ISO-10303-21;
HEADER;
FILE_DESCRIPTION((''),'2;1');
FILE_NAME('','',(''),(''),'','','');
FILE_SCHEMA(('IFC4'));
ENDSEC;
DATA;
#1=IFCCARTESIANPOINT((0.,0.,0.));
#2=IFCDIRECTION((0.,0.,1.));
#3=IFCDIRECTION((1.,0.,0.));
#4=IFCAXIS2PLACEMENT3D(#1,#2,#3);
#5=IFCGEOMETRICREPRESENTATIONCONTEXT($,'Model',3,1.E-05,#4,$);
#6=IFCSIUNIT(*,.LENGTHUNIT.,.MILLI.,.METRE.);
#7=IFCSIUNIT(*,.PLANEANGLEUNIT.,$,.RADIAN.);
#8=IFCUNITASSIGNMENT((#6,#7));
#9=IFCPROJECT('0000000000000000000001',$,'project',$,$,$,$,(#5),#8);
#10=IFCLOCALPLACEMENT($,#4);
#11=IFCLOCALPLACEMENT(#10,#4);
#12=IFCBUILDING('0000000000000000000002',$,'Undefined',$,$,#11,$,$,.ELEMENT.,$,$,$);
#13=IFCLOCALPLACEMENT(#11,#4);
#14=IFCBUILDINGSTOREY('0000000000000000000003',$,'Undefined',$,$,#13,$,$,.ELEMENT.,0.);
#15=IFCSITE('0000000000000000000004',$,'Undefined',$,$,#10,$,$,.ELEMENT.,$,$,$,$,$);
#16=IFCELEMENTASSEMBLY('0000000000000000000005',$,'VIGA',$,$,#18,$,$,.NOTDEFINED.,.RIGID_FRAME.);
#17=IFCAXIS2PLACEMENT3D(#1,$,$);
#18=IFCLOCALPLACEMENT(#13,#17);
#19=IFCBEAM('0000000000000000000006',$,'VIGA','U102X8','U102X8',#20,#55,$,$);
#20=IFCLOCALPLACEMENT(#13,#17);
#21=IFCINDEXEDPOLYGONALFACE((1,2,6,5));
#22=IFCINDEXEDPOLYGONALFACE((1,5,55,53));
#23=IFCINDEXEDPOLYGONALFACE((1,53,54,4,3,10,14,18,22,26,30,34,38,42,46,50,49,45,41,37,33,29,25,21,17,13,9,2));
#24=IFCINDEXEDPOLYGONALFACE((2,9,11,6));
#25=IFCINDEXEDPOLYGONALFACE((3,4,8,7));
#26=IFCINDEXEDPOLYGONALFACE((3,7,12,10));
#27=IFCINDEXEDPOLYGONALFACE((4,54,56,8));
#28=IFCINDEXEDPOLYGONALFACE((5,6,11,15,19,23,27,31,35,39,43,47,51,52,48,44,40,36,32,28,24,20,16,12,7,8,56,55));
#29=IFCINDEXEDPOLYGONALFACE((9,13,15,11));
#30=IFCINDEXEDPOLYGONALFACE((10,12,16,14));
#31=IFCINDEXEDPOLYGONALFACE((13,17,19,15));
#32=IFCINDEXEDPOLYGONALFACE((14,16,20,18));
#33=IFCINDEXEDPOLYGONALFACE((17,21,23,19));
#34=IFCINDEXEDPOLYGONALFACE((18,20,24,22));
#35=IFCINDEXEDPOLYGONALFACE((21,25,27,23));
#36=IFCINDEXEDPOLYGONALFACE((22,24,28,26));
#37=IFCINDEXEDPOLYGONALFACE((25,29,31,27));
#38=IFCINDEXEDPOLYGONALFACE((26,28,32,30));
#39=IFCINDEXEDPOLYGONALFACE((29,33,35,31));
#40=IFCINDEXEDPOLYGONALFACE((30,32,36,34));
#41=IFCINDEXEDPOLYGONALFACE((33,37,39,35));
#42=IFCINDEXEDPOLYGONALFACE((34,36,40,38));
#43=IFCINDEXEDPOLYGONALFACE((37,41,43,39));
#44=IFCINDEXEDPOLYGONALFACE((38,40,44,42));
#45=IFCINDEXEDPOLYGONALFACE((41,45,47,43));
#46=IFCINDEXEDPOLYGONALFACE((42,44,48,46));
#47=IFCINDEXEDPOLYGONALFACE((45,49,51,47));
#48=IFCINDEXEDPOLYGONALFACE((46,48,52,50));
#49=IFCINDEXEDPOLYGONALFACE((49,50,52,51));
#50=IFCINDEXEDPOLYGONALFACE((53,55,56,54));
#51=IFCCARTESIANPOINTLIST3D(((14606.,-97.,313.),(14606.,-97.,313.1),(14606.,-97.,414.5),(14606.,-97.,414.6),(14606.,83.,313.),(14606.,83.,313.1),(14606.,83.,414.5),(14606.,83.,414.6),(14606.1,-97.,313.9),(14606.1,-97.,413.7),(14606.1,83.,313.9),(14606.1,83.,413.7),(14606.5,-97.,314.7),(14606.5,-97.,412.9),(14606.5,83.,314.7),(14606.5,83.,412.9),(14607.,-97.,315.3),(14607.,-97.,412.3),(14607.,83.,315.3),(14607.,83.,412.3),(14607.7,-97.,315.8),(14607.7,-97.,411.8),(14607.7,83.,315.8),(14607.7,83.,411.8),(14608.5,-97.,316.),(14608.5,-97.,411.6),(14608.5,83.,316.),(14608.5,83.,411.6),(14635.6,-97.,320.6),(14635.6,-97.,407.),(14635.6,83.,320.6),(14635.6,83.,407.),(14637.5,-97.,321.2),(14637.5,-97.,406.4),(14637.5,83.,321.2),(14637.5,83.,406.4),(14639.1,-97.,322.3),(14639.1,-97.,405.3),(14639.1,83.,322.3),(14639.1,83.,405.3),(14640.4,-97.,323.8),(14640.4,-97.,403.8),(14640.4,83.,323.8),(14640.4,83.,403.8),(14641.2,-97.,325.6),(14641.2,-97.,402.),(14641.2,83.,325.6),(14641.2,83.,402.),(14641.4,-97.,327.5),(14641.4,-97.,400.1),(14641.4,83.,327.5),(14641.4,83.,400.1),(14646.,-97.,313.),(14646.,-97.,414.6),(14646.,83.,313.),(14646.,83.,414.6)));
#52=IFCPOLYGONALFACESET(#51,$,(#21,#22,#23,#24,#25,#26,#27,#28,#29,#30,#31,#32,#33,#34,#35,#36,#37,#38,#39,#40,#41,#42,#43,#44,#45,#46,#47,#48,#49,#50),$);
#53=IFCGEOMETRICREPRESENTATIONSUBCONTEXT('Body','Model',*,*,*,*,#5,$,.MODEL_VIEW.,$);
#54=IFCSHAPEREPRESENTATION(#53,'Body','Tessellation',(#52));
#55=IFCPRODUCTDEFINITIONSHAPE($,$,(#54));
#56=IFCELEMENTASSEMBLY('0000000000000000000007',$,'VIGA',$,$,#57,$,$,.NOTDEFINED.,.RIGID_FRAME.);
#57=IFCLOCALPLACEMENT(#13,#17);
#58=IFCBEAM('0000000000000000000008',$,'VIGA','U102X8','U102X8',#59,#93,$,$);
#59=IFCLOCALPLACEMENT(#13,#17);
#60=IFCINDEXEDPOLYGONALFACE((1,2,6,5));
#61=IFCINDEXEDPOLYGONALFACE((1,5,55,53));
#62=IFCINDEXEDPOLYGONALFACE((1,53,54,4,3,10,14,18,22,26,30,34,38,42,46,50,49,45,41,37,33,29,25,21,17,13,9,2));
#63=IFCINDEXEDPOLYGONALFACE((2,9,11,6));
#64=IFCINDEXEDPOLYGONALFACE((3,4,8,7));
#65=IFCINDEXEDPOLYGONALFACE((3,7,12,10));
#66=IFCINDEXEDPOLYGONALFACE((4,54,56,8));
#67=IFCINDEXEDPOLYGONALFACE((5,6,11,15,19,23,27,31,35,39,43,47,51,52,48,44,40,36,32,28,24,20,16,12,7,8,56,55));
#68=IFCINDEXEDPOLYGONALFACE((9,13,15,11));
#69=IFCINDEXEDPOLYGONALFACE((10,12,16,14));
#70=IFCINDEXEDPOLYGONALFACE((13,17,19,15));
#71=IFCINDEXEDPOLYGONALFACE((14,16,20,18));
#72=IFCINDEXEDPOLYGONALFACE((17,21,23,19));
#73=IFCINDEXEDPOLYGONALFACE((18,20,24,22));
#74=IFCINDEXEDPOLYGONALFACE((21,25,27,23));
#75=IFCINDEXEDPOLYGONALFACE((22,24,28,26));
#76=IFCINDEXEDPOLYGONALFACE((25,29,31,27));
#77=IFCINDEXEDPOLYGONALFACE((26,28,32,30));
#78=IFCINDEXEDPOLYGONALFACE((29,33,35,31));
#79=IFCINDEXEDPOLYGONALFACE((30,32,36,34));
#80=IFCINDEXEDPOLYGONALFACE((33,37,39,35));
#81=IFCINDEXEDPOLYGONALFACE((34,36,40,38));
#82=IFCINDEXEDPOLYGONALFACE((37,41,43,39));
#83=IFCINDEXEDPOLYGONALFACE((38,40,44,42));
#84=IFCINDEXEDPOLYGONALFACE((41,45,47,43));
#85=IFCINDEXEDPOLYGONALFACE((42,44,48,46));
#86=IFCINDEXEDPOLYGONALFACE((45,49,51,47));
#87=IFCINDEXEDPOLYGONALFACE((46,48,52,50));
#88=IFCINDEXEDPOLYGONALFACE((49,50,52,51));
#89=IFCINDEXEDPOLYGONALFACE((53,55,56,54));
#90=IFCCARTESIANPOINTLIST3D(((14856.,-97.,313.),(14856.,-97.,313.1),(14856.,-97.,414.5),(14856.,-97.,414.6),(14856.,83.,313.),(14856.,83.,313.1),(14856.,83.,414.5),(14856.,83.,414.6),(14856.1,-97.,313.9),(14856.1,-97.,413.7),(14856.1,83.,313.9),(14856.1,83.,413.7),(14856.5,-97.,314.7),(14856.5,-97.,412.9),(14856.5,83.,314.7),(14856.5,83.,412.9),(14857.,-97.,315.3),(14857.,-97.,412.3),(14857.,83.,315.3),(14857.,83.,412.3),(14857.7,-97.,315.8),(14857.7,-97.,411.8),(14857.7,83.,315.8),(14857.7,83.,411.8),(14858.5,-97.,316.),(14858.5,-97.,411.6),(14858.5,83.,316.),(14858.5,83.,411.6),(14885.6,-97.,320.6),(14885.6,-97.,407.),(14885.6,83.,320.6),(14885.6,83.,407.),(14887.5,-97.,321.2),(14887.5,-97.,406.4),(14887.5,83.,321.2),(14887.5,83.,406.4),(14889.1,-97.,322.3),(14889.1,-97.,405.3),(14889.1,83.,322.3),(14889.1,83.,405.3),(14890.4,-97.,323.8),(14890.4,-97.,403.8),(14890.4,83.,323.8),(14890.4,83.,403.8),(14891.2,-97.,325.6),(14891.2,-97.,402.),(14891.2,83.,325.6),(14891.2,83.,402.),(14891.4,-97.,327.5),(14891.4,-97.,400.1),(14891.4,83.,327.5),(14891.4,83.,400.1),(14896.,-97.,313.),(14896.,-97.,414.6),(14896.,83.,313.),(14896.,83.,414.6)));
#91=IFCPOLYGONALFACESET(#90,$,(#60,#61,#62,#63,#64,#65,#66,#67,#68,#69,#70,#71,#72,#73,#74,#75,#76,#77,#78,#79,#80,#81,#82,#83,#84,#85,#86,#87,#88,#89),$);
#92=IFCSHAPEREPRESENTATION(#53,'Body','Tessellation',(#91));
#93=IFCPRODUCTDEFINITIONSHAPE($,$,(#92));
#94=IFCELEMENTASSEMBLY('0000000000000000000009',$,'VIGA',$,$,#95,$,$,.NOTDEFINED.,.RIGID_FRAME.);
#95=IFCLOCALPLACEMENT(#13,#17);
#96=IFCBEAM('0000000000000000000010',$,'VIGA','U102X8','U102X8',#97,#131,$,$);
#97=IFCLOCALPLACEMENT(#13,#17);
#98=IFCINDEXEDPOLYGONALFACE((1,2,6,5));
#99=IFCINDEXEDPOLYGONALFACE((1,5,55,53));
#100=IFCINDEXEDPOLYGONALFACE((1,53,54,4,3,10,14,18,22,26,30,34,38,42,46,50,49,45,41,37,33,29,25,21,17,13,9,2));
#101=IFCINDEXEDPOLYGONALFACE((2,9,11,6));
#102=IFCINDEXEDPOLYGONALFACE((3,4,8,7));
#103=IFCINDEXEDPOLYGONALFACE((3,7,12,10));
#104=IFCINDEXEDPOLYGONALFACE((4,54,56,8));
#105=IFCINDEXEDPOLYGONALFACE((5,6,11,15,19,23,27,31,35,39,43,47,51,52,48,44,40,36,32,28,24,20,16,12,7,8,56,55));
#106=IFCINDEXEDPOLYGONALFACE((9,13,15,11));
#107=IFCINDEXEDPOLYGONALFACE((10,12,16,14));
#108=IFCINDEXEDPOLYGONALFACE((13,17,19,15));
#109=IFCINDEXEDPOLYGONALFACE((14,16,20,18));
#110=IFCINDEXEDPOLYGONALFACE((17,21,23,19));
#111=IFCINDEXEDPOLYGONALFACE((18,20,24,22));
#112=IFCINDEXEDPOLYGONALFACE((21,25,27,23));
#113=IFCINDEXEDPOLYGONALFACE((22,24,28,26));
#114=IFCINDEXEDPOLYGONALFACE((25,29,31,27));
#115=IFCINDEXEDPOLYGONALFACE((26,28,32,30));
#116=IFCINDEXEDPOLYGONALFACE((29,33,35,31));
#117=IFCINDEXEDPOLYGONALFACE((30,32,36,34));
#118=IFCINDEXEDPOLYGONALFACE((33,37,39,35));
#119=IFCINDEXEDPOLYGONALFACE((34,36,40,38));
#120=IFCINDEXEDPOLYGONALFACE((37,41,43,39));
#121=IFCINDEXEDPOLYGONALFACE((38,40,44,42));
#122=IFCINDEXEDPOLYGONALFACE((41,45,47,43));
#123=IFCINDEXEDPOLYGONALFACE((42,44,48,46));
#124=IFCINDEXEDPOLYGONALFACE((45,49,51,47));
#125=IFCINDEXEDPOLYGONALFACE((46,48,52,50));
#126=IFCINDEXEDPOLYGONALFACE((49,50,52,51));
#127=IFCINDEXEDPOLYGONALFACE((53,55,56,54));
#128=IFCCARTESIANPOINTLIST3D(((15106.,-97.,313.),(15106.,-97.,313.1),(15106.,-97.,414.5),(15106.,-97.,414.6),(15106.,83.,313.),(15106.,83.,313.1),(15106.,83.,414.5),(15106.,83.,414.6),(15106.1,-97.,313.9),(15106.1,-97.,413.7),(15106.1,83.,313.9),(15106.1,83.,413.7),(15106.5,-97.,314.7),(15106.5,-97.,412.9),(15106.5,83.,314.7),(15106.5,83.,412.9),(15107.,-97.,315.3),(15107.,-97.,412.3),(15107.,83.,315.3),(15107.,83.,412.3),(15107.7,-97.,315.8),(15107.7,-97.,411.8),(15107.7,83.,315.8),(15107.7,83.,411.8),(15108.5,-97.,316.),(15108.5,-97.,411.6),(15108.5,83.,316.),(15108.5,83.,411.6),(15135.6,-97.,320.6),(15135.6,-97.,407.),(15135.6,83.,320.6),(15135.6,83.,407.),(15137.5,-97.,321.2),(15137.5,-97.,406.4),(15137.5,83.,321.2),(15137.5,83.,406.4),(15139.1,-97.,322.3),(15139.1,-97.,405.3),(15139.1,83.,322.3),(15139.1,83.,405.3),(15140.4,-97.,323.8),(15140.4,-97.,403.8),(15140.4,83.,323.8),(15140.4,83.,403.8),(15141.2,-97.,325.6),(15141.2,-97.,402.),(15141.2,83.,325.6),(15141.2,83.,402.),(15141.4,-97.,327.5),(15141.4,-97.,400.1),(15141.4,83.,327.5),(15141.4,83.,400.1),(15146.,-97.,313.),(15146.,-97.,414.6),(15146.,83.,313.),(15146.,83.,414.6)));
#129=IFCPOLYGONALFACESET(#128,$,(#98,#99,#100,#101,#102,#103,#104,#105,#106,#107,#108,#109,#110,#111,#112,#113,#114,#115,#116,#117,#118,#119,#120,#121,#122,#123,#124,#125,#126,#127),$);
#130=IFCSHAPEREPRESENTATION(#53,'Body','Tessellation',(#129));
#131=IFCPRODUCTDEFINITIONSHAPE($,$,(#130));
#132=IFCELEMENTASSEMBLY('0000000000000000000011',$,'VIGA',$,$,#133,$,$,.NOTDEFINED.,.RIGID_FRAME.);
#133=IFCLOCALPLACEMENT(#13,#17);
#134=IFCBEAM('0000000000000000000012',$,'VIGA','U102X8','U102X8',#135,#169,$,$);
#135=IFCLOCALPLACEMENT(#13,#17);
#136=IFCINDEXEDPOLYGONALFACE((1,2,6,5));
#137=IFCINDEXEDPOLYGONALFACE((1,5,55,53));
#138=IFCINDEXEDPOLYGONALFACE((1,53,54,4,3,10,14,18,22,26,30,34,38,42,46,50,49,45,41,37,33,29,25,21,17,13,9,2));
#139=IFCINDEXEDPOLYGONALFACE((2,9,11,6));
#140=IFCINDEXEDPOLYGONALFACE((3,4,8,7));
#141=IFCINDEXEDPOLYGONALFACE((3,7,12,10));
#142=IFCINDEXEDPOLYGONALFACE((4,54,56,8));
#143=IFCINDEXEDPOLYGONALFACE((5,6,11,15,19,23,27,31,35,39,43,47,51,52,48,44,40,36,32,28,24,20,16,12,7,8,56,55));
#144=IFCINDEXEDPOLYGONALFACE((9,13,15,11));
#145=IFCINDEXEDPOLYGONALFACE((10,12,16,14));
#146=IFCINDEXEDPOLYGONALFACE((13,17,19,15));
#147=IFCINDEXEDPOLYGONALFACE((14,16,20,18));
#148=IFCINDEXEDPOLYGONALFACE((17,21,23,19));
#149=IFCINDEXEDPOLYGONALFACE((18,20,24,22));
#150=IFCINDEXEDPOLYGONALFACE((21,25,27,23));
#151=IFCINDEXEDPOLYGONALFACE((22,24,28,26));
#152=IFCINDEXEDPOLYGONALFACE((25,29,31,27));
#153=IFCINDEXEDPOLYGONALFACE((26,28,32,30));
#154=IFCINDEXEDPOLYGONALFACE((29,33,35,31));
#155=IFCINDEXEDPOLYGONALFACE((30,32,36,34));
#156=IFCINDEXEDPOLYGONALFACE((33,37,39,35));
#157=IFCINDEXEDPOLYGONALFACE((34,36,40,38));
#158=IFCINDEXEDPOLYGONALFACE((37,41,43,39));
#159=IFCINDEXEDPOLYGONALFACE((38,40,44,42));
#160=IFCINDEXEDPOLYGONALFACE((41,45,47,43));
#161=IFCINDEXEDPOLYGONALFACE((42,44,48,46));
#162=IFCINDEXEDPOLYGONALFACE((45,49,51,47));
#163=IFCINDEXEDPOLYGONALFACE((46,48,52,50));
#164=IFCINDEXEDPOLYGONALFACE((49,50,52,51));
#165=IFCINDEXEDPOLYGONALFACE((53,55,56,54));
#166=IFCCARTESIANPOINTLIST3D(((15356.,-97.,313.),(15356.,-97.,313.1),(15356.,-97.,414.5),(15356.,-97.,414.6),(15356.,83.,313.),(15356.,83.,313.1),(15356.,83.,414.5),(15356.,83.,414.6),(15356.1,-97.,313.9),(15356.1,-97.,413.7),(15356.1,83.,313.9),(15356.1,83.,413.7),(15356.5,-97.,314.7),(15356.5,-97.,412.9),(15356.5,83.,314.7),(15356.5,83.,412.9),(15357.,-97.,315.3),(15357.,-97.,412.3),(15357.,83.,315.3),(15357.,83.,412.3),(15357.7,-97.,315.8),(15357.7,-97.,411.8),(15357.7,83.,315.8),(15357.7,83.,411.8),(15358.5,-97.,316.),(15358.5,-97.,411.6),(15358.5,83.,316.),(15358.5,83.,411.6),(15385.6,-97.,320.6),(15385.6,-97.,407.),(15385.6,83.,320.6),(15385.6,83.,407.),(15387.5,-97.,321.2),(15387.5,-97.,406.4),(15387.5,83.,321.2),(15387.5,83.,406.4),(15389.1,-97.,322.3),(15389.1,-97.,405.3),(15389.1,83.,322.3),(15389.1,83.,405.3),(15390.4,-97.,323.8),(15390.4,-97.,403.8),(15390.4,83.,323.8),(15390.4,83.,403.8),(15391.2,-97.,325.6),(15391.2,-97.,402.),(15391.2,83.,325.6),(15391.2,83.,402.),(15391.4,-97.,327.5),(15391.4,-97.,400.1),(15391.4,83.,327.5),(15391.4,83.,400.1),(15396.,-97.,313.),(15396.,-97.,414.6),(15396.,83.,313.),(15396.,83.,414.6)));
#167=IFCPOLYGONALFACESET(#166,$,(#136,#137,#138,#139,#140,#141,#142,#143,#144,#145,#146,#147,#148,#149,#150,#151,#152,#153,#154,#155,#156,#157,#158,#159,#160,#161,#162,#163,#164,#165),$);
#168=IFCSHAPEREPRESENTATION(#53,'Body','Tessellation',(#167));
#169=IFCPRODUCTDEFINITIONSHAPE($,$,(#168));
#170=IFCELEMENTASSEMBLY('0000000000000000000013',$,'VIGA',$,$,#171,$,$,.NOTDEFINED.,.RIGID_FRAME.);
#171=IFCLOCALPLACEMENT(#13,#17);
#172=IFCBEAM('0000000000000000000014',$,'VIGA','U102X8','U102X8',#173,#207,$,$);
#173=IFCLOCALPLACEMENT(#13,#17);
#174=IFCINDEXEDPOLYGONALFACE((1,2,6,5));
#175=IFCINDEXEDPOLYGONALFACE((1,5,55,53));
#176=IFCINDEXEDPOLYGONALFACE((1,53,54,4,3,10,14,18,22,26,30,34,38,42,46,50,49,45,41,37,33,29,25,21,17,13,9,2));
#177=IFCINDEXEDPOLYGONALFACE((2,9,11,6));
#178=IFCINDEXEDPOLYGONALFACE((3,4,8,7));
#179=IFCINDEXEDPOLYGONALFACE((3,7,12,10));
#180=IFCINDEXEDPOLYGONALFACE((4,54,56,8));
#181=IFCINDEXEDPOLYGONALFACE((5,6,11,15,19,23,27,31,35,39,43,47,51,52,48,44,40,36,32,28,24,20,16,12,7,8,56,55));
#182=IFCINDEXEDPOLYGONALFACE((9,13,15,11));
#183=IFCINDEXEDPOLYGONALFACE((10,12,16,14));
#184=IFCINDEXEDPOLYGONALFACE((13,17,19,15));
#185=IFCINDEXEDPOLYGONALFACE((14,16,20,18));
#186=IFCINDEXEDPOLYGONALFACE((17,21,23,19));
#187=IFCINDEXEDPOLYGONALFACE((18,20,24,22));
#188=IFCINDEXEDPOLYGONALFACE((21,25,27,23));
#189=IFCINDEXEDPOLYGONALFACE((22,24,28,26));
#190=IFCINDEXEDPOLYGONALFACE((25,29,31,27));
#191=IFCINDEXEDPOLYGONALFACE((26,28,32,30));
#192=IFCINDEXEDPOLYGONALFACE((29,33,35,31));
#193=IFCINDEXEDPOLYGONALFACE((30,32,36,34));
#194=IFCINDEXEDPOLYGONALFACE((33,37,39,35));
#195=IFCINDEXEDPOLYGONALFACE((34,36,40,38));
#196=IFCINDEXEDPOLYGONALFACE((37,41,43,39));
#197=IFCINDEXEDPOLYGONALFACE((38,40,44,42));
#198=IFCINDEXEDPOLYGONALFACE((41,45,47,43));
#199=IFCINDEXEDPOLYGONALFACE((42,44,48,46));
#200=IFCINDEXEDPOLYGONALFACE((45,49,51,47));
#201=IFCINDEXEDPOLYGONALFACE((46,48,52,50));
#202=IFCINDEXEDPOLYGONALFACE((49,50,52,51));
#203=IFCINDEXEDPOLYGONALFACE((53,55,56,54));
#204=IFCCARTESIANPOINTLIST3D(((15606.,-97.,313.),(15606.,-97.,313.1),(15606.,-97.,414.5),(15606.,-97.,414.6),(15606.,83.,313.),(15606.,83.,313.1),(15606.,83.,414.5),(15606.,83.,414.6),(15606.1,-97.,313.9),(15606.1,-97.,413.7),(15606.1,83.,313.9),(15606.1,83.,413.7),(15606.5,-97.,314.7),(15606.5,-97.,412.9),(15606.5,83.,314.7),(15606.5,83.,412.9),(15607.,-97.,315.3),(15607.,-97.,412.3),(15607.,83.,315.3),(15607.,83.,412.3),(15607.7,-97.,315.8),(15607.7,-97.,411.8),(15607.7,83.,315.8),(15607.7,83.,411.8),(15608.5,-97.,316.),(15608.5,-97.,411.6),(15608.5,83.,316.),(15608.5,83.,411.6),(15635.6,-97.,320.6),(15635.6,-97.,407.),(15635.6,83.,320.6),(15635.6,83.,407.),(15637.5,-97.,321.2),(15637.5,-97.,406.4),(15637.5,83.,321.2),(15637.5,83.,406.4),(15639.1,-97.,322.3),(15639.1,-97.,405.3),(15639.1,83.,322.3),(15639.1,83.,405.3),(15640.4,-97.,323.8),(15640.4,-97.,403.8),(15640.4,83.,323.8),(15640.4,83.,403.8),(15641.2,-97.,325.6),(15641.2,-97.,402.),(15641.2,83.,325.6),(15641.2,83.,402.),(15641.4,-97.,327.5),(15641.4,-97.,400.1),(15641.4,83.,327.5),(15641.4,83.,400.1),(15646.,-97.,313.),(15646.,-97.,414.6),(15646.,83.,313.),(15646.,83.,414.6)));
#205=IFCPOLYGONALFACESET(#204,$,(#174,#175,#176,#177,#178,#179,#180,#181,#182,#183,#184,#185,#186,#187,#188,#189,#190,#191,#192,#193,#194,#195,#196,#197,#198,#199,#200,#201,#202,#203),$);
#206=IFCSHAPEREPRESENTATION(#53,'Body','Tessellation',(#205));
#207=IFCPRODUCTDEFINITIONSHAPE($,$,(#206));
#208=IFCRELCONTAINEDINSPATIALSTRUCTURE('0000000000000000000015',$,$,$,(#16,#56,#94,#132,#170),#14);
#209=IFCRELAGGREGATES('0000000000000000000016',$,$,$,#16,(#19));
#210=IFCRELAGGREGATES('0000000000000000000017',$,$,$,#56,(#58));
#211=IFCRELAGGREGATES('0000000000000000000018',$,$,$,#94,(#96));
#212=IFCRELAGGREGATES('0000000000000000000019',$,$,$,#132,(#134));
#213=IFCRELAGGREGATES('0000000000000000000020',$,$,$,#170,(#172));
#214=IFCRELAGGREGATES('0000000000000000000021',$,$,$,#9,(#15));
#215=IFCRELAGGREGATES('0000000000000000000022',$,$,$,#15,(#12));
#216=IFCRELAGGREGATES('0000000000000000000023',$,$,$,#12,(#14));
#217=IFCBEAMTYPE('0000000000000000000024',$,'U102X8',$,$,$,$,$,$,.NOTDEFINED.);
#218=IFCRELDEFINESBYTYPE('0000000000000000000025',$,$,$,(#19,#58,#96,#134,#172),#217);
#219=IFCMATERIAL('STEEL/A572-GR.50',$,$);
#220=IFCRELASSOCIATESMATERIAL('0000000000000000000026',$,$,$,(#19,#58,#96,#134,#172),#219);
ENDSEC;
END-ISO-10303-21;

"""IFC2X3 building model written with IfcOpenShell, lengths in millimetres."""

from ifc_helpers import new_model, si_unit, frame, origin_with_axes, origin_2d_with_axis, place, context, subcontext, project, spatial, u_section, extrude, material, type_object, element, aggregate, save


model = new_model("IFC2X3")

# Units and contexts
model_context = context("Model", 3, precision=1e-05, world=origin_with_axes())
body_context = subcontext(model_context, "Body", "Model", "MODEL_VIEW")
ifc_project = project(units=[si_unit("LENGTHUNIT", "METRE", prefix="MILLI"), si_unit("PLANEANGLEUNIT", "RADIAN")], contexts=[model_context])

# Site, building, storey
site_placement = place(None, origin_with_axes())
site = spatial("IfcSite", under=ifc_project, at=site_placement, Name="Undefined", CompositionType="ELEMENT")
building_placement = place(site_placement, origin_with_axes())
building = spatial("IfcBuilding", under=site, at=building_placement, Name="Undefined", CompositionType="ELEMENT")
storey_placement = place(building_placement, origin_with_axes())
storey = spatial("IfcBuildingStorey", under=building, at=storey_placement, Name="Undefined", CompositionType="ELEMENT", Elevation=0.0)

# Element assemblies, beams
ifc_material = material(Name="STEEL/A572-GR.50")
beam_type = type_object("IfcBeamType", Name="U102X8", PredefinedType="NOTDEFINED")
assembly_1_placement = place(storey_placement, origin_with_axes())
assembly_1 = element("IfcElementAssembly", 1, at=assembly_1_placement, inside=storey, Name="VIGA", AssemblyPlace="NOTDEFINED", PredefinedType="RIGID_FRAME")
beam_1_placement = place(assembly_1_placement, frame((14626.0, 83.0, 363.8), z_axis=(0.0, 0.0, 1.0), x_axis=(0.0, -1.0, 0.0)))
beam_1 = element("IfcBeam", 2, at=beam_1_placement, type_object=beam_type, material=ifc_material, Name="VIGA", Description="U102X8", ObjectType="U102X8", context=body_context, shape_type="SweptSolid", body=[
    extrude(u_section(Depth=101.6, FlangeWidth=40.0, WebThickness=4.6, FlangeThickness=6.0, FilletRadius=7.0, EdgeRadius=3.0, FlangeSlope=0.16839, at=origin_2d_with_axis()), frame((180.0, 0.0, 0.0), z_axis=(-1.0, 0.0, 0.0), x_axis=(0.0, -1.0, 0.0)), (0.0, 0.0, 1.0), 180.0),
])
aggregate(assembly_1, [beam_1])
assembly_2_placement = place(storey_placement, origin_with_axes())
assembly_2 = element("IfcElementAssembly", 3, at=assembly_2_placement, inside=storey, Name="VIGA", AssemblyPlace="NOTDEFINED", PredefinedType="RIGID_FRAME")
beam_2_placement = place(assembly_2_placement, frame((14876.0, 83.0, 363.8), z_axis=(0.0, 0.0, 1.0), x_axis=(0.0, -1.0, 0.0)))
beam_2 = element("IfcBeam", 4, at=beam_2_placement, type_object=beam_type, material=ifc_material, Name="VIGA", Description="U102X8", ObjectType="U102X8", context=body_context, shape_type="SweptSolid", body=[
    extrude(u_section(Depth=101.6, FlangeWidth=40.0, WebThickness=4.6, FlangeThickness=6.0, FilletRadius=7.0, EdgeRadius=3.0, FlangeSlope=0.16839, at=origin_2d_with_axis()), frame((180.0, 0.0, 0.0), z_axis=(-1.0, 0.0, 0.0), x_axis=(0.0, -1.0, 0.0)), (0.0, 0.0, 1.0), 180.0),
])
aggregate(assembly_2, [beam_2])
assembly_3_placement = place(storey_placement, origin_with_axes())
assembly_3 = element("IfcElementAssembly", 5, at=assembly_3_placement, inside=storey, Name="VIGA", AssemblyPlace="NOTDEFINED", PredefinedType="RIGID_FRAME")
beam_3_placement = place(assembly_3_placement, frame((15126.0, 83.0, 363.8), z_axis=(0.0, 0.0, 1.0), x_axis=(0.0, -1.0, 0.0)))
beam_3 = element("IfcBeam", 6, at=beam_3_placement, type_object=beam_type, material=ifc_material, Name="VIGA", Description="U102X8", ObjectType="U102X8", context=body_context, shape_type="SweptSolid", body=[
    extrude(u_section(Depth=101.6, FlangeWidth=40.0, WebThickness=4.6, FlangeThickness=6.0, FilletRadius=7.0, EdgeRadius=3.0, FlangeSlope=0.16839, at=origin_2d_with_axis()), frame((180.0, 0.0, 0.0), z_axis=(-1.0, 0.0, 0.0), x_axis=(0.0, -1.0, 0.0)), (0.0, 0.0, 1.0), 180.0),
])
aggregate(assembly_3, [beam_3])
assembly_4_placement = place(storey_placement, origin_with_axes())
assembly_4 = element("IfcElementAssembly", 7, at=assembly_4_placement, inside=storey, Name="VIGA", AssemblyPlace="NOTDEFINED", PredefinedType="RIGID_FRAME")
beam_4_placement = place(assembly_4_placement, frame((15376.0, 83.0, 363.8), z_axis=(0.0, 0.0, 1.0), x_axis=(0.0, -1.0, 0.0)))
beam_4 = element("IfcBeam", 8, at=beam_4_placement, type_object=beam_type, material=ifc_material, Name="VIGA", Description="U102X8", ObjectType="U102X8", context=body_context, shape_type="SweptSolid", body=[
    extrude(u_section(Depth=101.6, FlangeWidth=40.0, WebThickness=4.6, FlangeThickness=6.0, FilletRadius=7.0, EdgeRadius=3.0, FlangeSlope=0.16839, at=origin_2d_with_axis()), frame((180.0, 0.0, 0.0), z_axis=(-1.0, 0.0, 0.0), x_axis=(0.0, -1.0, 0.0)), (0.0, 0.0, 1.0), 180.0),
])
aggregate(assembly_4, [beam_4])
assembly_5_placement = place(storey_placement, origin_with_axes())
assembly_5 = element("IfcElementAssembly", 9, at=assembly_5_placement, inside=storey, Name="VIGA", AssemblyPlace="NOTDEFINED", PredefinedType="RIGID_FRAME")
beam_5_placement = place(assembly_5_placement, frame((15626.0, 83.0, 363.8), z_axis=(0.0, 0.0, 1.0), x_axis=(0.0, -1.0, 0.0)))
beam_5 = element("IfcBeam", 10, at=beam_5_placement, type_object=beam_type, material=ifc_material, Name="VIGA", Description="U102X8", ObjectType="U102X8", context=body_context, shape_type="SweptSolid", body=[
    extrude(u_section(Depth=101.6, FlangeWidth=40.0, WebThickness=4.6, FlangeThickness=6.0, FilletRadius=7.0, EdgeRadius=3.0, FlangeSlope=0.16839, at=origin_2d_with_axis()), frame((180.0, 0.0, 0.0), z_axis=(-1.0, 0.0, 0.0), x_axis=(0.0, -1.0, 0.0)), (0.0, 0.0, 1.0), 180.0),
])
aggregate(assembly_5, [beam_5])

save(model, "model.ifc")
